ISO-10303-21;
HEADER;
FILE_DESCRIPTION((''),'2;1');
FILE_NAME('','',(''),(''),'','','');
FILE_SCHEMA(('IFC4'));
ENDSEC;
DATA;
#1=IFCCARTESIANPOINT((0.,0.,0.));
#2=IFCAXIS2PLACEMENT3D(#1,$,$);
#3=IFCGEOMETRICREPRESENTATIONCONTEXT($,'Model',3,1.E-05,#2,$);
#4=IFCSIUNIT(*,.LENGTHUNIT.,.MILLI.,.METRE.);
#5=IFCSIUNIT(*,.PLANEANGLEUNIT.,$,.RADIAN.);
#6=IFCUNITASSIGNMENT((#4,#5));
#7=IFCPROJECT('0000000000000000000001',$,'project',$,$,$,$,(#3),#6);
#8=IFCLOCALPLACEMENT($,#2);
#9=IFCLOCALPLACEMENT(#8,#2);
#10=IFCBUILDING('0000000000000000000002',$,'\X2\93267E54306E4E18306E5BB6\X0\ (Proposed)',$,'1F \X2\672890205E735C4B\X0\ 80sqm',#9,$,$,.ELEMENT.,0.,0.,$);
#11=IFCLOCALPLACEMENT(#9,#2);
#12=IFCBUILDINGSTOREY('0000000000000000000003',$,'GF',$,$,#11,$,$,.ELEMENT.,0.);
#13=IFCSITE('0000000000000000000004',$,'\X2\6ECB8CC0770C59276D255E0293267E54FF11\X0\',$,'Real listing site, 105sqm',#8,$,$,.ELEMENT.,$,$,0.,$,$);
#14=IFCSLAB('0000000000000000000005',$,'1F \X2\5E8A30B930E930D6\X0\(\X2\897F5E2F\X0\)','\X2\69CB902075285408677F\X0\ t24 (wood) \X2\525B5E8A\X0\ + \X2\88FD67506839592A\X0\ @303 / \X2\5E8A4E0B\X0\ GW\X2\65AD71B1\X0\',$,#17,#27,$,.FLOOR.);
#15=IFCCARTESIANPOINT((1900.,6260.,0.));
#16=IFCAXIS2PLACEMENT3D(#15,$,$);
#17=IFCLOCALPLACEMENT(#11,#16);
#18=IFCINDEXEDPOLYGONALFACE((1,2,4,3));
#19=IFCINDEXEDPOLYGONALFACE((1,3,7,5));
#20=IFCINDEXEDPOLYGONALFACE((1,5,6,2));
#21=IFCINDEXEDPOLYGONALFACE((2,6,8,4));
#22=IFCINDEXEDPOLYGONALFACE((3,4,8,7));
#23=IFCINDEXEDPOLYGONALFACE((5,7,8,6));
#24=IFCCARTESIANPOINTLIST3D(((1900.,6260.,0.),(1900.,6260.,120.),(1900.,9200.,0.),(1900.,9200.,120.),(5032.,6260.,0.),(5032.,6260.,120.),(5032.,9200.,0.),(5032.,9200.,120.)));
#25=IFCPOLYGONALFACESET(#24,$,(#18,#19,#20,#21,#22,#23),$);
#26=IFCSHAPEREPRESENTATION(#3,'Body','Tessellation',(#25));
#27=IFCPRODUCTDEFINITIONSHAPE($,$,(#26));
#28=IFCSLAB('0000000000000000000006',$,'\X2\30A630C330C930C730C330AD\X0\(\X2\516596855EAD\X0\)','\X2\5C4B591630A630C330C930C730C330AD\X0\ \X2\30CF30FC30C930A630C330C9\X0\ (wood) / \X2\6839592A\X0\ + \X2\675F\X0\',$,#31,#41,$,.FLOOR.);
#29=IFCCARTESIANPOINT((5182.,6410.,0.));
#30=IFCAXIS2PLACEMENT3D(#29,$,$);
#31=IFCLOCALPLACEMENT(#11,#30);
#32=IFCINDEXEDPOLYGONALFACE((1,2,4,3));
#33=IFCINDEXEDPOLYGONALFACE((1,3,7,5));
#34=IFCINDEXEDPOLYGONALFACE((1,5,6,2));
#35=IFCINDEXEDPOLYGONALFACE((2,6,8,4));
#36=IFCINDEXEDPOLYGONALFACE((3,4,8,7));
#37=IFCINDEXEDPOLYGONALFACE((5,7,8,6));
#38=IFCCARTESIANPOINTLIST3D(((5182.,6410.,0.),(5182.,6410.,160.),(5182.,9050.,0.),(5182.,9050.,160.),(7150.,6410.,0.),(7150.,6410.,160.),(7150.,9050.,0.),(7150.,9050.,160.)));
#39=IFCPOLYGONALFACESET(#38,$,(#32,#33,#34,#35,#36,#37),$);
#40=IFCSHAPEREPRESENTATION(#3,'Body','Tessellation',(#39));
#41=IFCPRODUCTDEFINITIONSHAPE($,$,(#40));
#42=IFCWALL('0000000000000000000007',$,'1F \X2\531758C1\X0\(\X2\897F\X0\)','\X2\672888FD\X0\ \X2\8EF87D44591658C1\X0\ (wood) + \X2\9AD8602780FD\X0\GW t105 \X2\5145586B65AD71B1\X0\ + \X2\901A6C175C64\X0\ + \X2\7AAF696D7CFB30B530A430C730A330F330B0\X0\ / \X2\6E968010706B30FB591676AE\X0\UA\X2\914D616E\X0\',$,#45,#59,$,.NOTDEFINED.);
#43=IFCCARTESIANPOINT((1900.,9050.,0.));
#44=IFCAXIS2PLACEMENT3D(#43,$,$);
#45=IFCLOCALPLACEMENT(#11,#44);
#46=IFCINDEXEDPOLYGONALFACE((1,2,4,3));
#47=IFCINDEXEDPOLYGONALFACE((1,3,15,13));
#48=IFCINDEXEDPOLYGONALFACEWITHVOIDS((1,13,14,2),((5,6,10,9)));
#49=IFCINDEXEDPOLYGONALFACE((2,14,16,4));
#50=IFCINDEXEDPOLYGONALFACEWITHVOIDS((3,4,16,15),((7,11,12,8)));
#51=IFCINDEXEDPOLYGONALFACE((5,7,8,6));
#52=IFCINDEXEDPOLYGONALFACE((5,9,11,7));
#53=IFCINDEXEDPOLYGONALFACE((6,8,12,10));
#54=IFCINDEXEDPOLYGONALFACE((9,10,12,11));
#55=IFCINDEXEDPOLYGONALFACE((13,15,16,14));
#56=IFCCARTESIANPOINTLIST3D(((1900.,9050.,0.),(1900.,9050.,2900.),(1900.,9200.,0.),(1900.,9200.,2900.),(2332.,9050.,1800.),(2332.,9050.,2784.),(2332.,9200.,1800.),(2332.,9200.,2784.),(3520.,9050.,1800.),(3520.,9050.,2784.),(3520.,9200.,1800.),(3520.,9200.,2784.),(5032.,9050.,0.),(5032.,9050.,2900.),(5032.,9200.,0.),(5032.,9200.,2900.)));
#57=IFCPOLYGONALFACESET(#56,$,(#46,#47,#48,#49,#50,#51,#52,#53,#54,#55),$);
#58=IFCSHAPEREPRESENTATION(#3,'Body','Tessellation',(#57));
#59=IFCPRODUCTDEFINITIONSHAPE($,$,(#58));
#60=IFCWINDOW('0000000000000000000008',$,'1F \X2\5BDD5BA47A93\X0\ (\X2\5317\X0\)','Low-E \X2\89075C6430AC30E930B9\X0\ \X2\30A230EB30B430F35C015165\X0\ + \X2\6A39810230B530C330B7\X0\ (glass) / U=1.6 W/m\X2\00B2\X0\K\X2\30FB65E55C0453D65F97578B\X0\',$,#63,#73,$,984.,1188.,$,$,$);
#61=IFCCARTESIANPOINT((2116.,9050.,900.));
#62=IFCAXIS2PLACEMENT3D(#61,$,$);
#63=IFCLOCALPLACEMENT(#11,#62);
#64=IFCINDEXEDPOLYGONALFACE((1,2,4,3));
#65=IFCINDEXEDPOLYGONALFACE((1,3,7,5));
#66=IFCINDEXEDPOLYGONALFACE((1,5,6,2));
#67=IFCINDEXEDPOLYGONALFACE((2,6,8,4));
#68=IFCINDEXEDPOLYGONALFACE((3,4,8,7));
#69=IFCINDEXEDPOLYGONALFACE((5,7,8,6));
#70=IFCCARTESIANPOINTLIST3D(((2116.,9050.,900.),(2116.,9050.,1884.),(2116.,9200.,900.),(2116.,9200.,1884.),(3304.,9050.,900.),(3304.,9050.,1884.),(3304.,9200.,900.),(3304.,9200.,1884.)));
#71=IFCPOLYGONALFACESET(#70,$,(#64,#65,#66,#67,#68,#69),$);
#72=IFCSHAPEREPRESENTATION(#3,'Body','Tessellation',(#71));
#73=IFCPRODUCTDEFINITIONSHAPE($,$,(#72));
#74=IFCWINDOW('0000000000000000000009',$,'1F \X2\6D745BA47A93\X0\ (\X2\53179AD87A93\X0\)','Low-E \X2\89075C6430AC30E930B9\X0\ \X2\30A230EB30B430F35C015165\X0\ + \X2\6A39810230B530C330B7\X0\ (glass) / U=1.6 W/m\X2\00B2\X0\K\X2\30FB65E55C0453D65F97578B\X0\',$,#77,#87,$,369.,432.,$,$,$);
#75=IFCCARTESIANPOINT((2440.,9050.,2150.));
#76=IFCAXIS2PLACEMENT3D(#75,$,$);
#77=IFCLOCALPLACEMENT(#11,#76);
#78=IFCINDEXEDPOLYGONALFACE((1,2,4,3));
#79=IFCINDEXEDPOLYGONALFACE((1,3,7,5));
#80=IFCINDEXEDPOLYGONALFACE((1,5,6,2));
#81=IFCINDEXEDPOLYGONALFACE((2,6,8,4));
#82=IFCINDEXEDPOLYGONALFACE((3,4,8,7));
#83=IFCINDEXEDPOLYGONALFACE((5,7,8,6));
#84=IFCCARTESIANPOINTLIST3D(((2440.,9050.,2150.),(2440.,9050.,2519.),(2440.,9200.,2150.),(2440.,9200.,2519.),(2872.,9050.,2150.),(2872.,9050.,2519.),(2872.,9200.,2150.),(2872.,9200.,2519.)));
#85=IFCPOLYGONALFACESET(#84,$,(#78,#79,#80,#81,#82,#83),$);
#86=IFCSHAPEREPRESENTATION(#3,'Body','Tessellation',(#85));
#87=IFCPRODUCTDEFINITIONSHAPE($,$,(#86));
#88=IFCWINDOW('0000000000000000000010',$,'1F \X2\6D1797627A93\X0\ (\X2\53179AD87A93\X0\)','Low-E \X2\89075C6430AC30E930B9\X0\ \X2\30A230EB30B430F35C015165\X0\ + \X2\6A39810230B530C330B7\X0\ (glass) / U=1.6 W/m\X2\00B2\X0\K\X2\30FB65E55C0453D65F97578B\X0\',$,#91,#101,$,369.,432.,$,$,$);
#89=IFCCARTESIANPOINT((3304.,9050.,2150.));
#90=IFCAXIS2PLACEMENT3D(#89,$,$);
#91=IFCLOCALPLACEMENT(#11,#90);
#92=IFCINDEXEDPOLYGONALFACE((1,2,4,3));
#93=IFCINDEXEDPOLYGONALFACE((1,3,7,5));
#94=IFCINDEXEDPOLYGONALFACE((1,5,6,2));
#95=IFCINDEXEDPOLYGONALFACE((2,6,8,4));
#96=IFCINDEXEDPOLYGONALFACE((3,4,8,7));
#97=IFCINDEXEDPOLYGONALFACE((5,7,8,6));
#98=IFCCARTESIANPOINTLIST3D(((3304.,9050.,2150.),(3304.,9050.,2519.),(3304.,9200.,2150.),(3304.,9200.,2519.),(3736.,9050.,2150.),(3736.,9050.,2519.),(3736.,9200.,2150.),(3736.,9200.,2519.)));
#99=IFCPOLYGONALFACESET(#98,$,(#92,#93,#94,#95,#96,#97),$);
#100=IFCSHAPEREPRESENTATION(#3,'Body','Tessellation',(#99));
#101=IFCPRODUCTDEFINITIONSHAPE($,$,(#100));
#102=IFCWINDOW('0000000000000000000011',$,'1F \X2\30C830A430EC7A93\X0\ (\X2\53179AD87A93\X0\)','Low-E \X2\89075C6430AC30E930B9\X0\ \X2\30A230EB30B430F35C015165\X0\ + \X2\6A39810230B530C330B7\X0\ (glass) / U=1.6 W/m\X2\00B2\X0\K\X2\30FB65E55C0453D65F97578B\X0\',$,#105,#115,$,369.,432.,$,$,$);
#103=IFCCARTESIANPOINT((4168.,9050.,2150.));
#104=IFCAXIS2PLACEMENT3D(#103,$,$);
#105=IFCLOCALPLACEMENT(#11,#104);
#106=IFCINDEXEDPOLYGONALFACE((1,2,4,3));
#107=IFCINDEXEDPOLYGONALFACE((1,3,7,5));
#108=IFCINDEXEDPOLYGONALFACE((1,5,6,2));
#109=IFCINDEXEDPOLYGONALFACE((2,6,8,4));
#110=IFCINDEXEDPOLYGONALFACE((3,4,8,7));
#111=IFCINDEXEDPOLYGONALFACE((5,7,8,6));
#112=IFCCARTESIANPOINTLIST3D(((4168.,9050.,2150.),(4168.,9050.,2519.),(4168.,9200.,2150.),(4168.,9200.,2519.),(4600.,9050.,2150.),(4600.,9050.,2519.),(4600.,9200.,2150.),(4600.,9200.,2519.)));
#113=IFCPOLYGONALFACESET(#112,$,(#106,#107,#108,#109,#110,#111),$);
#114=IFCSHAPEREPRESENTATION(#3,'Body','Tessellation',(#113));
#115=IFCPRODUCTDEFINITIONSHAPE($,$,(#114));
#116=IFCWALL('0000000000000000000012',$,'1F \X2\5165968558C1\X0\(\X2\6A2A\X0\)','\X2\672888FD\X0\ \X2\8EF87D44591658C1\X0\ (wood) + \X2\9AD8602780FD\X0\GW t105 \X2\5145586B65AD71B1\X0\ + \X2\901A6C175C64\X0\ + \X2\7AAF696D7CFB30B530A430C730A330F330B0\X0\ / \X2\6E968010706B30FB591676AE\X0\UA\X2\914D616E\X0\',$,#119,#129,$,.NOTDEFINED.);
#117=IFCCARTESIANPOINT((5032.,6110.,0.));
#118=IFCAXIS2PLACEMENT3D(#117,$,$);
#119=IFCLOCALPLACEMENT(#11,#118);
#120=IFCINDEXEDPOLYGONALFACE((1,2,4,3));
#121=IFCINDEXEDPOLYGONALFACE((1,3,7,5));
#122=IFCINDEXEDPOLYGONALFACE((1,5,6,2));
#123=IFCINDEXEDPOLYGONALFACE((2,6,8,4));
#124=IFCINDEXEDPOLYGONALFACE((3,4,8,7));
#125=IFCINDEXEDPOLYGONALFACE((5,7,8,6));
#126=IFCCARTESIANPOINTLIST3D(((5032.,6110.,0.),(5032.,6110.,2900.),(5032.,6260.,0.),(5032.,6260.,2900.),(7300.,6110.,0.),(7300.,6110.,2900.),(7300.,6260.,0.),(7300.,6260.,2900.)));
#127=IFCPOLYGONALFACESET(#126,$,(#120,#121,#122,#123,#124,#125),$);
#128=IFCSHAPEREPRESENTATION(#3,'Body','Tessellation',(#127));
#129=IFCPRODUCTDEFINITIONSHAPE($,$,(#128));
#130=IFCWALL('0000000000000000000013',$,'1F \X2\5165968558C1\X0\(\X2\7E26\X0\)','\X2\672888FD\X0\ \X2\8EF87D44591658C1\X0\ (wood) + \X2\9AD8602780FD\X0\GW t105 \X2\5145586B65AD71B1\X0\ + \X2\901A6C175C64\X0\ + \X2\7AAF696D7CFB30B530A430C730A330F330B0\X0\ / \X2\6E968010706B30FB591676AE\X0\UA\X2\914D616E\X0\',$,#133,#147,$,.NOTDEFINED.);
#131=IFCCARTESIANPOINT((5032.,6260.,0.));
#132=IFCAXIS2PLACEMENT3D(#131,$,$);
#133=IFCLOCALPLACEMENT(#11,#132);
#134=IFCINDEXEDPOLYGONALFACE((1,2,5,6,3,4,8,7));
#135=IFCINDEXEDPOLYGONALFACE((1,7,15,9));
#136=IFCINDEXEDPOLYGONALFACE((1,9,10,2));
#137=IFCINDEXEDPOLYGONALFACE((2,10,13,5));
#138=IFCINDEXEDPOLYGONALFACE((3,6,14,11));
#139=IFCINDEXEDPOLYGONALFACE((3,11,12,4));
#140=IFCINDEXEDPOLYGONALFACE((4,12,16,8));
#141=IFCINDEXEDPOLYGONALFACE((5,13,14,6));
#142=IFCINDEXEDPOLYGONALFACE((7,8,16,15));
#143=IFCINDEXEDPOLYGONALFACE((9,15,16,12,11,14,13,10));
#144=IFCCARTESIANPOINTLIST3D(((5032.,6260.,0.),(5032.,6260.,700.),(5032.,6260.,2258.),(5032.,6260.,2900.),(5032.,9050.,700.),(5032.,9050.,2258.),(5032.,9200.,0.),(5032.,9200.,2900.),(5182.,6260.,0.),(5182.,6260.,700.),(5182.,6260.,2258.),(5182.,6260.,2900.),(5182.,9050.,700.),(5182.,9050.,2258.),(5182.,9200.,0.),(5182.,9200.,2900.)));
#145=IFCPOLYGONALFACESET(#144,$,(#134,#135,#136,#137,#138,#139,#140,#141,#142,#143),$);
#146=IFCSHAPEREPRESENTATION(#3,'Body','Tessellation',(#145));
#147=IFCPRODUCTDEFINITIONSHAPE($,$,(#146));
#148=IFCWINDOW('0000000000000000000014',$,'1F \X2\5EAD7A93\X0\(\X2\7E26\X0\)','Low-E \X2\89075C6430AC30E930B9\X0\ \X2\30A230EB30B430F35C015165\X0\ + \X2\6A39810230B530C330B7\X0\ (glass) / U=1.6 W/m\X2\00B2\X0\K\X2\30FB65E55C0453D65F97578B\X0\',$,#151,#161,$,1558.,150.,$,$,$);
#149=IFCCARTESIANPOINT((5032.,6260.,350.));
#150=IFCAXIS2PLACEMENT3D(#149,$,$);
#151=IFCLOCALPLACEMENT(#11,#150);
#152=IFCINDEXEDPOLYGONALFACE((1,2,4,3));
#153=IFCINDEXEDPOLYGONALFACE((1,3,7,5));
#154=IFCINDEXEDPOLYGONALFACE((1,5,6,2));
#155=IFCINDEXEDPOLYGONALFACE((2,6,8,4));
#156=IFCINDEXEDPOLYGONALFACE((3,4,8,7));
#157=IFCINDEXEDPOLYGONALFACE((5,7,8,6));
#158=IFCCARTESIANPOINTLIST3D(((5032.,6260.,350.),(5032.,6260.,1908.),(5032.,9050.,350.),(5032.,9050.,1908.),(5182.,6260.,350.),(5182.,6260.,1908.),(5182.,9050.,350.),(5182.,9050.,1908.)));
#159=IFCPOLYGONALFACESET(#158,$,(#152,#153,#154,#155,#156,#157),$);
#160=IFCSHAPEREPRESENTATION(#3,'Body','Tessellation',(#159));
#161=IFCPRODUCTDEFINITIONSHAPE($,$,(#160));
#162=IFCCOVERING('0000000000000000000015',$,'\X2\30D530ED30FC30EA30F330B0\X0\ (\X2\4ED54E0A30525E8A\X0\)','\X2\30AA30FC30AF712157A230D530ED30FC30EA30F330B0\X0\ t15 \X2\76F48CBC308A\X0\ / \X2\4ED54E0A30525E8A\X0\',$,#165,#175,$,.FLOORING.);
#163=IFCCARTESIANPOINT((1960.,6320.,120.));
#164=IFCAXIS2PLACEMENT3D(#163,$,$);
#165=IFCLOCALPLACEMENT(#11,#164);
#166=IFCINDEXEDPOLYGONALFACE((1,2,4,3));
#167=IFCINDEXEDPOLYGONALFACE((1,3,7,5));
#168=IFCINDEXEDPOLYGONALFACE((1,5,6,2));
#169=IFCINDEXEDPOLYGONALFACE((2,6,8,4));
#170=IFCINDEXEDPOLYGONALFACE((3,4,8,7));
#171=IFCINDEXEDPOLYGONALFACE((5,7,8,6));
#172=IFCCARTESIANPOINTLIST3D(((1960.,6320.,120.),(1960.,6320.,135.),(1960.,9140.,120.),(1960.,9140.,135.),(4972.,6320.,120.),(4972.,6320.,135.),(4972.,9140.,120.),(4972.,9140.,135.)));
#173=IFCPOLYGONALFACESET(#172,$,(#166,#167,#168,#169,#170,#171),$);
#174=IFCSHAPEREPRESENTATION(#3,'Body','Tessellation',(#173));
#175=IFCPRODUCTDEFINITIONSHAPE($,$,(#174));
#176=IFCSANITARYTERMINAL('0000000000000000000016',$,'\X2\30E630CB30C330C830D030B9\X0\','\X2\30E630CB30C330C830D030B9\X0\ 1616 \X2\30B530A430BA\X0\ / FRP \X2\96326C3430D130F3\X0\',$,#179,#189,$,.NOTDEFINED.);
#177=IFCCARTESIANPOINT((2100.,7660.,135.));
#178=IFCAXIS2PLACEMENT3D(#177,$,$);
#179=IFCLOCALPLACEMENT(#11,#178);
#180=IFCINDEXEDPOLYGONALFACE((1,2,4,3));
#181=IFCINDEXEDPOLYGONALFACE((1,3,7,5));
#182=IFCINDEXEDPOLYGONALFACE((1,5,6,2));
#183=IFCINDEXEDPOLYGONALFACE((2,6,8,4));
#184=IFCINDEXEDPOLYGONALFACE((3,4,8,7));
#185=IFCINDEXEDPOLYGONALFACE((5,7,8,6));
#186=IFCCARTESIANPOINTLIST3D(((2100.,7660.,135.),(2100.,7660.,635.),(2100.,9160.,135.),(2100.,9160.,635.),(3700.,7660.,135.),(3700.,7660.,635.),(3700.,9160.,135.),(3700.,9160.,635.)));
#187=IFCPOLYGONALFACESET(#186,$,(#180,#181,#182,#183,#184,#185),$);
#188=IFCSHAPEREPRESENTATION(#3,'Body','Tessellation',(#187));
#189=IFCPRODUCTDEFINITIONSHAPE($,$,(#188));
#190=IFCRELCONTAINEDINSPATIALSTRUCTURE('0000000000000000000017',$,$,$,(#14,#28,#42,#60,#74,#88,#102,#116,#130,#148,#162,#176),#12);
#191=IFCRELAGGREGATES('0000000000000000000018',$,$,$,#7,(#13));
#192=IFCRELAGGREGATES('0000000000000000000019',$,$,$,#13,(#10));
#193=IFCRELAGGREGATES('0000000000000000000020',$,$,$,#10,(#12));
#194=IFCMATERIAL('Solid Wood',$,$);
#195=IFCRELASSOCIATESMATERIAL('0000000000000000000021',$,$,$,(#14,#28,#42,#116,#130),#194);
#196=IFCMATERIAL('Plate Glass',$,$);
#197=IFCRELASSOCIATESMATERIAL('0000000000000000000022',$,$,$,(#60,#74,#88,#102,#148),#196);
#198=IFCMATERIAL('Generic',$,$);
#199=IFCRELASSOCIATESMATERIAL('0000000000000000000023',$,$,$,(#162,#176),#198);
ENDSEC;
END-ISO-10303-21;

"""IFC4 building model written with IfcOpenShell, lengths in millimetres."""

from ifc_helpers import new_model, si_unit, frame, frame_2d, origin, place, context, project, spatial, rectangle, extrude, material, element, fill, save


model = new_model("IFC4")

# Units and contexts
model_context = context("Model", 3, precision=1e-05, world=origin())
ifc_project = project(units=[si_unit("LENGTHUNIT", "METRE", prefix="MILLI"), si_unit("PLANEANGLEUNIT", "RADIAN")], contexts=[model_context])

# Site, building, storey
site_placement = place(None, origin())
site = spatial("IfcSite", under=ifc_project, at=site_placement, Name="滋賀県大津市錦織１", ObjectType="Real listing site, 105sqm", CompositionType="ELEMENT", RefElevation=0.0)
building_placement = place(site_placement, origin())
building = spatial("IfcBuilding", under=site, at=building_placement, Name="錦織の丘の家 (Proposed)", ObjectType="1F 木造平屋 80sqm", CompositionType="ELEMENT", ElevationOfRefHeight=0.0, ElevationOfTerrain=0.0)
storey_placement = place(building_placement, origin())
storey = spatial("IfcBuildingStorey", under=building, at=storey_placement, Name="GF", CompositionType="ELEMENT", Elevation=0.0)

# Slabs
ifc_material_1 = material(Name="Solid Wood")
slab_1_placement = place(storey_placement, frame((1900.0, 6260.0, 0.0)))
element("IfcSlab", 1, at=slab_1_placement, inside=storey, material=ifc_material_1, Name="1F 床スラブ(西帯)", Description="構造用合板 t24 (wood) 剛床 + 製材根太 @303 / 床下 GW断熱", PredefinedType="FLOOR", context=model_context, shape_type="SweptSolid", body=[
    extrude(rectangle(XDim=3132.0, YDim=2940.0, at=frame_2d((1566.0, 1470.0))), frame((1900.0, 6260.0, 0.0)), (0.0, 0.0, 1.0), 120.0),
])
slab_2_placement = place(storey_placement, frame((5182.0, 6410.0, 0.0)))
element("IfcSlab", 2, at=slab_2_placement, inside=storey, material=ifc_material_1, Name="ウッドデッキ(入隅庭)", Description="屋外ウッドデッキ ハードウッド (wood) / 根太 + 束", PredefinedType="FLOOR", context=model_context, shape_type="SweptSolid", body=[
    extrude(rectangle(XDim=1968.0, YDim=2640.0, at=frame_2d((984.0, 1320.0))), frame((5182.0, 6410.0, 0.0)), (0.0, 0.0, 1.0), 160.0),
])

# Wall, openings, windows
wall_1_placement = place(storey_placement, frame((1900.0, 9050.0, 0.0)))
wall_1 = element("IfcWall", 3, at=wall_1_placement, inside=storey, material=ifc_material_1, Name="1F 北壁(西)", Description="木製 軸組外壁 (wood) + 高性能GW t105 充填断熱 + 通気層 + 窯業系サイディング / 準耐火・外皮UA配慮", PredefinedType="NOTDEFINED", context=model_context, shape_type="SweptSolid", body=[
    extrude(rectangle(XDim=3132.0, YDim=150.0, at=frame_2d((1566.0, 75.0))), frame((1900.0, 9050.0, 0.0)), (0.0, 0.0, 1.0), 2900.0),
])
opening_1_placement = place(storey_placement, frame((2116.0, 9050.0, 900.0)))
opening_1 = element("IfcOpeningElement", 4, at=opening_1_placement, cuts=wall_1, PredefinedType="NOTDEFINED", context=model_context, shape_type="SweptSolid", body=[
    extrude(rectangle(XDim=1188.0, YDim=150.0, at=frame_2d((594.0, 75.0))), frame((2116.0, 9050.0, 900.0)), (0.0, 0.0, 1.0), 984.0),
])
opening_2_placement = place(storey_placement, frame((2440.0, 9050.0, 2150.0)))
opening_2 = element("IfcOpeningElement", 5, at=opening_2_placement, cuts=wall_1, PredefinedType="NOTDEFINED", context=model_context, shape_type="SweptSolid", body=[
    extrude(rectangle(XDim=432.0, YDim=150.0, at=frame_2d((216.0, 75.0))), frame((2440.0, 9050.0, 2150.0)), (0.0, 0.0, 1.0), 369.0),
])
opening_3_placement = place(storey_placement, frame((3304.0, 9050.0, 2150.0)))
opening_3 = element("IfcOpeningElement", 6, at=opening_3_placement, cuts=wall_1, PredefinedType="NOTDEFINED", context=model_context, shape_type="SweptSolid", body=[
    extrude(rectangle(XDim=432.0, YDim=150.0, at=frame_2d((216.0, 75.0))), frame((3304.0, 9050.0, 2150.0)), (0.0, 0.0, 1.0), 369.0),
])
opening_4_placement = place(storey_placement, frame((4168.0, 9050.0, 2150.0)))
opening_4 = element("IfcOpeningElement", 7, at=opening_4_placement, cuts=wall_1, PredefinedType="NOTDEFINED", context=model_context, shape_type="SweptSolid", body=[
    extrude(rectangle(XDim=432.0, YDim=150.0, at=frame_2d((216.0, 75.0))), frame((4168.0, 9050.0, 2150.0)), (0.0, 0.0, 1.0), 369.0),
])
ifc_material_2 = material(Name="Plate Glass")
window_1_placement = place(storey_placement, frame((2116.0, 9050.0, 900.0)))
window_1 = element("IfcWindow", 8, at=window_1_placement, inside=storey, material=ifc_material_2, Name="1F 寝室窓 (北)", Description="Low-E 複層ガラス アルゴン封入 + 樹脂サッシ (glass) / U=1.6 W/m²K・日射取得型", OverallHeight=984.0, OverallWidth=1188.0, context=model_context, shape_type="SweptSolid", body=[
    extrude(rectangle(XDim=1188.0, YDim=150.0, at=frame_2d((594.0, 75.0))), frame((2116.0, 9050.0, 900.0)), (0.0, 0.0, 1.0), 984.0),
])
fill(opening_1, window_1)
window_2_placement = place(storey_placement, frame((2440.0, 9050.0, 2150.0)))
window_2 = element("IfcWindow", 9, at=window_2_placement, inside=storey, material=ifc_material_2, Name="1F 浴室窓 (北高窓)", Description="Low-E 複層ガラス アルゴン封入 + 樹脂サッシ (glass) / U=1.6 W/m²K・日射取得型", OverallHeight=369.0, OverallWidth=432.0, context=model_context, shape_type="SweptSolid", body=[
    extrude(rectangle(XDim=432.0, YDim=150.0, at=frame_2d((216.0, 75.0))), frame((2440.0, 9050.0, 2150.0)), (0.0, 0.0, 1.0), 369.0),
])
fill(opening_2, window_2)
window_3_placement = place(storey_placement, frame((3304.0, 9050.0, 2150.0)))
window_3 = element("IfcWindow", 10, at=window_3_placement, inside=storey, material=ifc_material_2, Name="1F 洗面窓 (北高窓)", Description="Low-E 複層ガラス アルゴン封入 + 樹脂サッシ (glass) / U=1.6 W/m²K・日射取得型", OverallHeight=369.0, OverallWidth=432.0, context=model_context, shape_type="SweptSolid", body=[
    extrude(rectangle(XDim=432.0, YDim=150.0, at=frame_2d((216.0, 75.0))), frame((3304.0, 9050.0, 2150.0)), (0.0, 0.0, 1.0), 369.0),
])
fill(opening_3, window_3)
window_4_placement = place(storey_placement, frame((4168.0, 9050.0, 2150.0)))
window_4 = element("IfcWindow", 11, at=window_4_placement, inside=storey, material=ifc_material_2, Name="1F トイレ窓 (北高窓)", Description="Low-E 複層ガラス アルゴン封入 + 樹脂サッシ (glass) / U=1.6 W/m²K・日射取得型", OverallHeight=369.0, OverallWidth=432.0, context=model_context, shape_type="SweptSolid", body=[
    extrude(rectangle(XDim=432.0, YDim=150.0, at=frame_2d((216.0, 75.0))), frame((4168.0, 9050.0, 2150.0)), (0.0, 0.0, 1.0), 369.0),
])
fill(opening_4, window_4)

# Wall
wall_2_placement = place(storey_placement, frame((5032.0, 6110.0, 0.0)))
element("IfcWall", 12, at=wall_2_placement, inside=storey, material=ifc_material_1, Name="1F 入隅壁(横)", Description="木製 軸組外壁 (wood) + 高性能GW t105 充填断熱 + 通気層 + 窯業系サイディング / 準耐火・外皮UA配慮", PredefinedType="NOTDEFINED", context=model_context, shape_type="SweptSolid", body=[
    extrude(rectangle(XDim=2268.0, YDim=150.0, at=frame_2d((1134.0, 75.0))), frame((5032.0, 6110.0, 0.0)), (0.0, 0.0, 1.0), 2900.0),
])

# Wall, opening, window
wall_3_placement = place(storey_placement, frame((5032.0, 6260.0, 0.0)))
wall_3 = element("IfcWall", 13, at=wall_3_placement, inside=storey, material=ifc_material_1, Name="1F 入隅壁(縦)", Description="木製 軸組外壁 (wood) + 高性能GW t105 充填断熱 + 通気層 + 窯業系サイディング / 準耐火・外皮UA配慮", PredefinedType="NOTDEFINED", context=model_context, shape_type="SweptSolid", body=[
    extrude(rectangle(XDim=150.0, YDim=2940.0, at=frame_2d((75.0, 1470.0))), frame((5032.0, 6260.0, 0.0)), (0.0, 0.0, 1.0), 2900.0),
])
opening_5_placement = place(storey_placement, frame((5032.0, 6260.0, 350.0)))
opening_5 = element("IfcOpeningElement", 14, at=opening_5_placement, cuts=wall_3, PredefinedType="NOTDEFINED", context=model_context, shape_type="SweptSolid", body=[
    extrude(rectangle(XDim=150.0, YDim=2790.0, at=frame_2d((75.0, 1395.0))), frame((5032.0, 6260.0, 350.0)), (0.0, 0.0, 1.0), 1558.0),
])
window_5_placement = place(storey_placement, frame((5032.0, 6260.0, 350.0)))
window_5 = element("IfcWindow", 15, at=window_5_placement, inside=storey, material=ifc_material_2, Name="1F 庭窓(縦)", Description="Low-E 複層ガラス アルゴン封入 + 樹脂サッシ (glass) / U=1.6 W/m²K・日射取得型", OverallHeight=1558.0, OverallWidth=150.0, context=model_context, shape_type="SweptSolid", body=[
    extrude(rectangle(XDim=150.0, YDim=2790.0, at=frame_2d((75.0, 1395.0))), frame((5032.0, 6260.0, 350.0)), (0.0, 0.0, 1.0), 1558.0),
])
fill(opening_5, window_5)

# Covering
ifc_material_3 = material(Name="Generic")
covering_placement = place(storey_placement, frame((1960.0, 6320.0, 120.0)))
element("IfcCovering", 16, at=covering_placement, inside=storey, material=ifc_material_3, Name="フローリング (仕上げ床)", Description="オーク無垢フローリング t15 直貼り / 仕上げ床", PredefinedType="FLOORING", context=model_context, shape_type="SweptSolid", body=[
    extrude(rectangle(XDim=3012.0, YDim=2820.0, at=frame_2d((1506.0, 1410.0))), frame((1960.0, 6320.0, 120.0)), (0.0, 0.0, 1.0), 15.0),
])

# Sanitary terminal
sanitary_terminal_1_placement = place(storey_placement, frame((2100.0, 7660.0, 135.0)))
element("IfcSanitaryTerminal", 17, at=sanitary_terminal_1_placement, inside=storey, material=ifc_material_3, Name="ユニットバス", Description="ユニットバス 1616 サイズ / FRP 防水パン", PredefinedType="NOTDEFINED", context=model_context, shape_type="SweptSolid", body=[
    extrude(rectangle(XDim=1600.0, YDim=1500.0, at=frame_2d((800.0, 750.0))), frame((2100.0, 7660.0, 135.0)), (0.0, 0.0, 1.0), 500.0),
])

save(model, "model.ifc")
